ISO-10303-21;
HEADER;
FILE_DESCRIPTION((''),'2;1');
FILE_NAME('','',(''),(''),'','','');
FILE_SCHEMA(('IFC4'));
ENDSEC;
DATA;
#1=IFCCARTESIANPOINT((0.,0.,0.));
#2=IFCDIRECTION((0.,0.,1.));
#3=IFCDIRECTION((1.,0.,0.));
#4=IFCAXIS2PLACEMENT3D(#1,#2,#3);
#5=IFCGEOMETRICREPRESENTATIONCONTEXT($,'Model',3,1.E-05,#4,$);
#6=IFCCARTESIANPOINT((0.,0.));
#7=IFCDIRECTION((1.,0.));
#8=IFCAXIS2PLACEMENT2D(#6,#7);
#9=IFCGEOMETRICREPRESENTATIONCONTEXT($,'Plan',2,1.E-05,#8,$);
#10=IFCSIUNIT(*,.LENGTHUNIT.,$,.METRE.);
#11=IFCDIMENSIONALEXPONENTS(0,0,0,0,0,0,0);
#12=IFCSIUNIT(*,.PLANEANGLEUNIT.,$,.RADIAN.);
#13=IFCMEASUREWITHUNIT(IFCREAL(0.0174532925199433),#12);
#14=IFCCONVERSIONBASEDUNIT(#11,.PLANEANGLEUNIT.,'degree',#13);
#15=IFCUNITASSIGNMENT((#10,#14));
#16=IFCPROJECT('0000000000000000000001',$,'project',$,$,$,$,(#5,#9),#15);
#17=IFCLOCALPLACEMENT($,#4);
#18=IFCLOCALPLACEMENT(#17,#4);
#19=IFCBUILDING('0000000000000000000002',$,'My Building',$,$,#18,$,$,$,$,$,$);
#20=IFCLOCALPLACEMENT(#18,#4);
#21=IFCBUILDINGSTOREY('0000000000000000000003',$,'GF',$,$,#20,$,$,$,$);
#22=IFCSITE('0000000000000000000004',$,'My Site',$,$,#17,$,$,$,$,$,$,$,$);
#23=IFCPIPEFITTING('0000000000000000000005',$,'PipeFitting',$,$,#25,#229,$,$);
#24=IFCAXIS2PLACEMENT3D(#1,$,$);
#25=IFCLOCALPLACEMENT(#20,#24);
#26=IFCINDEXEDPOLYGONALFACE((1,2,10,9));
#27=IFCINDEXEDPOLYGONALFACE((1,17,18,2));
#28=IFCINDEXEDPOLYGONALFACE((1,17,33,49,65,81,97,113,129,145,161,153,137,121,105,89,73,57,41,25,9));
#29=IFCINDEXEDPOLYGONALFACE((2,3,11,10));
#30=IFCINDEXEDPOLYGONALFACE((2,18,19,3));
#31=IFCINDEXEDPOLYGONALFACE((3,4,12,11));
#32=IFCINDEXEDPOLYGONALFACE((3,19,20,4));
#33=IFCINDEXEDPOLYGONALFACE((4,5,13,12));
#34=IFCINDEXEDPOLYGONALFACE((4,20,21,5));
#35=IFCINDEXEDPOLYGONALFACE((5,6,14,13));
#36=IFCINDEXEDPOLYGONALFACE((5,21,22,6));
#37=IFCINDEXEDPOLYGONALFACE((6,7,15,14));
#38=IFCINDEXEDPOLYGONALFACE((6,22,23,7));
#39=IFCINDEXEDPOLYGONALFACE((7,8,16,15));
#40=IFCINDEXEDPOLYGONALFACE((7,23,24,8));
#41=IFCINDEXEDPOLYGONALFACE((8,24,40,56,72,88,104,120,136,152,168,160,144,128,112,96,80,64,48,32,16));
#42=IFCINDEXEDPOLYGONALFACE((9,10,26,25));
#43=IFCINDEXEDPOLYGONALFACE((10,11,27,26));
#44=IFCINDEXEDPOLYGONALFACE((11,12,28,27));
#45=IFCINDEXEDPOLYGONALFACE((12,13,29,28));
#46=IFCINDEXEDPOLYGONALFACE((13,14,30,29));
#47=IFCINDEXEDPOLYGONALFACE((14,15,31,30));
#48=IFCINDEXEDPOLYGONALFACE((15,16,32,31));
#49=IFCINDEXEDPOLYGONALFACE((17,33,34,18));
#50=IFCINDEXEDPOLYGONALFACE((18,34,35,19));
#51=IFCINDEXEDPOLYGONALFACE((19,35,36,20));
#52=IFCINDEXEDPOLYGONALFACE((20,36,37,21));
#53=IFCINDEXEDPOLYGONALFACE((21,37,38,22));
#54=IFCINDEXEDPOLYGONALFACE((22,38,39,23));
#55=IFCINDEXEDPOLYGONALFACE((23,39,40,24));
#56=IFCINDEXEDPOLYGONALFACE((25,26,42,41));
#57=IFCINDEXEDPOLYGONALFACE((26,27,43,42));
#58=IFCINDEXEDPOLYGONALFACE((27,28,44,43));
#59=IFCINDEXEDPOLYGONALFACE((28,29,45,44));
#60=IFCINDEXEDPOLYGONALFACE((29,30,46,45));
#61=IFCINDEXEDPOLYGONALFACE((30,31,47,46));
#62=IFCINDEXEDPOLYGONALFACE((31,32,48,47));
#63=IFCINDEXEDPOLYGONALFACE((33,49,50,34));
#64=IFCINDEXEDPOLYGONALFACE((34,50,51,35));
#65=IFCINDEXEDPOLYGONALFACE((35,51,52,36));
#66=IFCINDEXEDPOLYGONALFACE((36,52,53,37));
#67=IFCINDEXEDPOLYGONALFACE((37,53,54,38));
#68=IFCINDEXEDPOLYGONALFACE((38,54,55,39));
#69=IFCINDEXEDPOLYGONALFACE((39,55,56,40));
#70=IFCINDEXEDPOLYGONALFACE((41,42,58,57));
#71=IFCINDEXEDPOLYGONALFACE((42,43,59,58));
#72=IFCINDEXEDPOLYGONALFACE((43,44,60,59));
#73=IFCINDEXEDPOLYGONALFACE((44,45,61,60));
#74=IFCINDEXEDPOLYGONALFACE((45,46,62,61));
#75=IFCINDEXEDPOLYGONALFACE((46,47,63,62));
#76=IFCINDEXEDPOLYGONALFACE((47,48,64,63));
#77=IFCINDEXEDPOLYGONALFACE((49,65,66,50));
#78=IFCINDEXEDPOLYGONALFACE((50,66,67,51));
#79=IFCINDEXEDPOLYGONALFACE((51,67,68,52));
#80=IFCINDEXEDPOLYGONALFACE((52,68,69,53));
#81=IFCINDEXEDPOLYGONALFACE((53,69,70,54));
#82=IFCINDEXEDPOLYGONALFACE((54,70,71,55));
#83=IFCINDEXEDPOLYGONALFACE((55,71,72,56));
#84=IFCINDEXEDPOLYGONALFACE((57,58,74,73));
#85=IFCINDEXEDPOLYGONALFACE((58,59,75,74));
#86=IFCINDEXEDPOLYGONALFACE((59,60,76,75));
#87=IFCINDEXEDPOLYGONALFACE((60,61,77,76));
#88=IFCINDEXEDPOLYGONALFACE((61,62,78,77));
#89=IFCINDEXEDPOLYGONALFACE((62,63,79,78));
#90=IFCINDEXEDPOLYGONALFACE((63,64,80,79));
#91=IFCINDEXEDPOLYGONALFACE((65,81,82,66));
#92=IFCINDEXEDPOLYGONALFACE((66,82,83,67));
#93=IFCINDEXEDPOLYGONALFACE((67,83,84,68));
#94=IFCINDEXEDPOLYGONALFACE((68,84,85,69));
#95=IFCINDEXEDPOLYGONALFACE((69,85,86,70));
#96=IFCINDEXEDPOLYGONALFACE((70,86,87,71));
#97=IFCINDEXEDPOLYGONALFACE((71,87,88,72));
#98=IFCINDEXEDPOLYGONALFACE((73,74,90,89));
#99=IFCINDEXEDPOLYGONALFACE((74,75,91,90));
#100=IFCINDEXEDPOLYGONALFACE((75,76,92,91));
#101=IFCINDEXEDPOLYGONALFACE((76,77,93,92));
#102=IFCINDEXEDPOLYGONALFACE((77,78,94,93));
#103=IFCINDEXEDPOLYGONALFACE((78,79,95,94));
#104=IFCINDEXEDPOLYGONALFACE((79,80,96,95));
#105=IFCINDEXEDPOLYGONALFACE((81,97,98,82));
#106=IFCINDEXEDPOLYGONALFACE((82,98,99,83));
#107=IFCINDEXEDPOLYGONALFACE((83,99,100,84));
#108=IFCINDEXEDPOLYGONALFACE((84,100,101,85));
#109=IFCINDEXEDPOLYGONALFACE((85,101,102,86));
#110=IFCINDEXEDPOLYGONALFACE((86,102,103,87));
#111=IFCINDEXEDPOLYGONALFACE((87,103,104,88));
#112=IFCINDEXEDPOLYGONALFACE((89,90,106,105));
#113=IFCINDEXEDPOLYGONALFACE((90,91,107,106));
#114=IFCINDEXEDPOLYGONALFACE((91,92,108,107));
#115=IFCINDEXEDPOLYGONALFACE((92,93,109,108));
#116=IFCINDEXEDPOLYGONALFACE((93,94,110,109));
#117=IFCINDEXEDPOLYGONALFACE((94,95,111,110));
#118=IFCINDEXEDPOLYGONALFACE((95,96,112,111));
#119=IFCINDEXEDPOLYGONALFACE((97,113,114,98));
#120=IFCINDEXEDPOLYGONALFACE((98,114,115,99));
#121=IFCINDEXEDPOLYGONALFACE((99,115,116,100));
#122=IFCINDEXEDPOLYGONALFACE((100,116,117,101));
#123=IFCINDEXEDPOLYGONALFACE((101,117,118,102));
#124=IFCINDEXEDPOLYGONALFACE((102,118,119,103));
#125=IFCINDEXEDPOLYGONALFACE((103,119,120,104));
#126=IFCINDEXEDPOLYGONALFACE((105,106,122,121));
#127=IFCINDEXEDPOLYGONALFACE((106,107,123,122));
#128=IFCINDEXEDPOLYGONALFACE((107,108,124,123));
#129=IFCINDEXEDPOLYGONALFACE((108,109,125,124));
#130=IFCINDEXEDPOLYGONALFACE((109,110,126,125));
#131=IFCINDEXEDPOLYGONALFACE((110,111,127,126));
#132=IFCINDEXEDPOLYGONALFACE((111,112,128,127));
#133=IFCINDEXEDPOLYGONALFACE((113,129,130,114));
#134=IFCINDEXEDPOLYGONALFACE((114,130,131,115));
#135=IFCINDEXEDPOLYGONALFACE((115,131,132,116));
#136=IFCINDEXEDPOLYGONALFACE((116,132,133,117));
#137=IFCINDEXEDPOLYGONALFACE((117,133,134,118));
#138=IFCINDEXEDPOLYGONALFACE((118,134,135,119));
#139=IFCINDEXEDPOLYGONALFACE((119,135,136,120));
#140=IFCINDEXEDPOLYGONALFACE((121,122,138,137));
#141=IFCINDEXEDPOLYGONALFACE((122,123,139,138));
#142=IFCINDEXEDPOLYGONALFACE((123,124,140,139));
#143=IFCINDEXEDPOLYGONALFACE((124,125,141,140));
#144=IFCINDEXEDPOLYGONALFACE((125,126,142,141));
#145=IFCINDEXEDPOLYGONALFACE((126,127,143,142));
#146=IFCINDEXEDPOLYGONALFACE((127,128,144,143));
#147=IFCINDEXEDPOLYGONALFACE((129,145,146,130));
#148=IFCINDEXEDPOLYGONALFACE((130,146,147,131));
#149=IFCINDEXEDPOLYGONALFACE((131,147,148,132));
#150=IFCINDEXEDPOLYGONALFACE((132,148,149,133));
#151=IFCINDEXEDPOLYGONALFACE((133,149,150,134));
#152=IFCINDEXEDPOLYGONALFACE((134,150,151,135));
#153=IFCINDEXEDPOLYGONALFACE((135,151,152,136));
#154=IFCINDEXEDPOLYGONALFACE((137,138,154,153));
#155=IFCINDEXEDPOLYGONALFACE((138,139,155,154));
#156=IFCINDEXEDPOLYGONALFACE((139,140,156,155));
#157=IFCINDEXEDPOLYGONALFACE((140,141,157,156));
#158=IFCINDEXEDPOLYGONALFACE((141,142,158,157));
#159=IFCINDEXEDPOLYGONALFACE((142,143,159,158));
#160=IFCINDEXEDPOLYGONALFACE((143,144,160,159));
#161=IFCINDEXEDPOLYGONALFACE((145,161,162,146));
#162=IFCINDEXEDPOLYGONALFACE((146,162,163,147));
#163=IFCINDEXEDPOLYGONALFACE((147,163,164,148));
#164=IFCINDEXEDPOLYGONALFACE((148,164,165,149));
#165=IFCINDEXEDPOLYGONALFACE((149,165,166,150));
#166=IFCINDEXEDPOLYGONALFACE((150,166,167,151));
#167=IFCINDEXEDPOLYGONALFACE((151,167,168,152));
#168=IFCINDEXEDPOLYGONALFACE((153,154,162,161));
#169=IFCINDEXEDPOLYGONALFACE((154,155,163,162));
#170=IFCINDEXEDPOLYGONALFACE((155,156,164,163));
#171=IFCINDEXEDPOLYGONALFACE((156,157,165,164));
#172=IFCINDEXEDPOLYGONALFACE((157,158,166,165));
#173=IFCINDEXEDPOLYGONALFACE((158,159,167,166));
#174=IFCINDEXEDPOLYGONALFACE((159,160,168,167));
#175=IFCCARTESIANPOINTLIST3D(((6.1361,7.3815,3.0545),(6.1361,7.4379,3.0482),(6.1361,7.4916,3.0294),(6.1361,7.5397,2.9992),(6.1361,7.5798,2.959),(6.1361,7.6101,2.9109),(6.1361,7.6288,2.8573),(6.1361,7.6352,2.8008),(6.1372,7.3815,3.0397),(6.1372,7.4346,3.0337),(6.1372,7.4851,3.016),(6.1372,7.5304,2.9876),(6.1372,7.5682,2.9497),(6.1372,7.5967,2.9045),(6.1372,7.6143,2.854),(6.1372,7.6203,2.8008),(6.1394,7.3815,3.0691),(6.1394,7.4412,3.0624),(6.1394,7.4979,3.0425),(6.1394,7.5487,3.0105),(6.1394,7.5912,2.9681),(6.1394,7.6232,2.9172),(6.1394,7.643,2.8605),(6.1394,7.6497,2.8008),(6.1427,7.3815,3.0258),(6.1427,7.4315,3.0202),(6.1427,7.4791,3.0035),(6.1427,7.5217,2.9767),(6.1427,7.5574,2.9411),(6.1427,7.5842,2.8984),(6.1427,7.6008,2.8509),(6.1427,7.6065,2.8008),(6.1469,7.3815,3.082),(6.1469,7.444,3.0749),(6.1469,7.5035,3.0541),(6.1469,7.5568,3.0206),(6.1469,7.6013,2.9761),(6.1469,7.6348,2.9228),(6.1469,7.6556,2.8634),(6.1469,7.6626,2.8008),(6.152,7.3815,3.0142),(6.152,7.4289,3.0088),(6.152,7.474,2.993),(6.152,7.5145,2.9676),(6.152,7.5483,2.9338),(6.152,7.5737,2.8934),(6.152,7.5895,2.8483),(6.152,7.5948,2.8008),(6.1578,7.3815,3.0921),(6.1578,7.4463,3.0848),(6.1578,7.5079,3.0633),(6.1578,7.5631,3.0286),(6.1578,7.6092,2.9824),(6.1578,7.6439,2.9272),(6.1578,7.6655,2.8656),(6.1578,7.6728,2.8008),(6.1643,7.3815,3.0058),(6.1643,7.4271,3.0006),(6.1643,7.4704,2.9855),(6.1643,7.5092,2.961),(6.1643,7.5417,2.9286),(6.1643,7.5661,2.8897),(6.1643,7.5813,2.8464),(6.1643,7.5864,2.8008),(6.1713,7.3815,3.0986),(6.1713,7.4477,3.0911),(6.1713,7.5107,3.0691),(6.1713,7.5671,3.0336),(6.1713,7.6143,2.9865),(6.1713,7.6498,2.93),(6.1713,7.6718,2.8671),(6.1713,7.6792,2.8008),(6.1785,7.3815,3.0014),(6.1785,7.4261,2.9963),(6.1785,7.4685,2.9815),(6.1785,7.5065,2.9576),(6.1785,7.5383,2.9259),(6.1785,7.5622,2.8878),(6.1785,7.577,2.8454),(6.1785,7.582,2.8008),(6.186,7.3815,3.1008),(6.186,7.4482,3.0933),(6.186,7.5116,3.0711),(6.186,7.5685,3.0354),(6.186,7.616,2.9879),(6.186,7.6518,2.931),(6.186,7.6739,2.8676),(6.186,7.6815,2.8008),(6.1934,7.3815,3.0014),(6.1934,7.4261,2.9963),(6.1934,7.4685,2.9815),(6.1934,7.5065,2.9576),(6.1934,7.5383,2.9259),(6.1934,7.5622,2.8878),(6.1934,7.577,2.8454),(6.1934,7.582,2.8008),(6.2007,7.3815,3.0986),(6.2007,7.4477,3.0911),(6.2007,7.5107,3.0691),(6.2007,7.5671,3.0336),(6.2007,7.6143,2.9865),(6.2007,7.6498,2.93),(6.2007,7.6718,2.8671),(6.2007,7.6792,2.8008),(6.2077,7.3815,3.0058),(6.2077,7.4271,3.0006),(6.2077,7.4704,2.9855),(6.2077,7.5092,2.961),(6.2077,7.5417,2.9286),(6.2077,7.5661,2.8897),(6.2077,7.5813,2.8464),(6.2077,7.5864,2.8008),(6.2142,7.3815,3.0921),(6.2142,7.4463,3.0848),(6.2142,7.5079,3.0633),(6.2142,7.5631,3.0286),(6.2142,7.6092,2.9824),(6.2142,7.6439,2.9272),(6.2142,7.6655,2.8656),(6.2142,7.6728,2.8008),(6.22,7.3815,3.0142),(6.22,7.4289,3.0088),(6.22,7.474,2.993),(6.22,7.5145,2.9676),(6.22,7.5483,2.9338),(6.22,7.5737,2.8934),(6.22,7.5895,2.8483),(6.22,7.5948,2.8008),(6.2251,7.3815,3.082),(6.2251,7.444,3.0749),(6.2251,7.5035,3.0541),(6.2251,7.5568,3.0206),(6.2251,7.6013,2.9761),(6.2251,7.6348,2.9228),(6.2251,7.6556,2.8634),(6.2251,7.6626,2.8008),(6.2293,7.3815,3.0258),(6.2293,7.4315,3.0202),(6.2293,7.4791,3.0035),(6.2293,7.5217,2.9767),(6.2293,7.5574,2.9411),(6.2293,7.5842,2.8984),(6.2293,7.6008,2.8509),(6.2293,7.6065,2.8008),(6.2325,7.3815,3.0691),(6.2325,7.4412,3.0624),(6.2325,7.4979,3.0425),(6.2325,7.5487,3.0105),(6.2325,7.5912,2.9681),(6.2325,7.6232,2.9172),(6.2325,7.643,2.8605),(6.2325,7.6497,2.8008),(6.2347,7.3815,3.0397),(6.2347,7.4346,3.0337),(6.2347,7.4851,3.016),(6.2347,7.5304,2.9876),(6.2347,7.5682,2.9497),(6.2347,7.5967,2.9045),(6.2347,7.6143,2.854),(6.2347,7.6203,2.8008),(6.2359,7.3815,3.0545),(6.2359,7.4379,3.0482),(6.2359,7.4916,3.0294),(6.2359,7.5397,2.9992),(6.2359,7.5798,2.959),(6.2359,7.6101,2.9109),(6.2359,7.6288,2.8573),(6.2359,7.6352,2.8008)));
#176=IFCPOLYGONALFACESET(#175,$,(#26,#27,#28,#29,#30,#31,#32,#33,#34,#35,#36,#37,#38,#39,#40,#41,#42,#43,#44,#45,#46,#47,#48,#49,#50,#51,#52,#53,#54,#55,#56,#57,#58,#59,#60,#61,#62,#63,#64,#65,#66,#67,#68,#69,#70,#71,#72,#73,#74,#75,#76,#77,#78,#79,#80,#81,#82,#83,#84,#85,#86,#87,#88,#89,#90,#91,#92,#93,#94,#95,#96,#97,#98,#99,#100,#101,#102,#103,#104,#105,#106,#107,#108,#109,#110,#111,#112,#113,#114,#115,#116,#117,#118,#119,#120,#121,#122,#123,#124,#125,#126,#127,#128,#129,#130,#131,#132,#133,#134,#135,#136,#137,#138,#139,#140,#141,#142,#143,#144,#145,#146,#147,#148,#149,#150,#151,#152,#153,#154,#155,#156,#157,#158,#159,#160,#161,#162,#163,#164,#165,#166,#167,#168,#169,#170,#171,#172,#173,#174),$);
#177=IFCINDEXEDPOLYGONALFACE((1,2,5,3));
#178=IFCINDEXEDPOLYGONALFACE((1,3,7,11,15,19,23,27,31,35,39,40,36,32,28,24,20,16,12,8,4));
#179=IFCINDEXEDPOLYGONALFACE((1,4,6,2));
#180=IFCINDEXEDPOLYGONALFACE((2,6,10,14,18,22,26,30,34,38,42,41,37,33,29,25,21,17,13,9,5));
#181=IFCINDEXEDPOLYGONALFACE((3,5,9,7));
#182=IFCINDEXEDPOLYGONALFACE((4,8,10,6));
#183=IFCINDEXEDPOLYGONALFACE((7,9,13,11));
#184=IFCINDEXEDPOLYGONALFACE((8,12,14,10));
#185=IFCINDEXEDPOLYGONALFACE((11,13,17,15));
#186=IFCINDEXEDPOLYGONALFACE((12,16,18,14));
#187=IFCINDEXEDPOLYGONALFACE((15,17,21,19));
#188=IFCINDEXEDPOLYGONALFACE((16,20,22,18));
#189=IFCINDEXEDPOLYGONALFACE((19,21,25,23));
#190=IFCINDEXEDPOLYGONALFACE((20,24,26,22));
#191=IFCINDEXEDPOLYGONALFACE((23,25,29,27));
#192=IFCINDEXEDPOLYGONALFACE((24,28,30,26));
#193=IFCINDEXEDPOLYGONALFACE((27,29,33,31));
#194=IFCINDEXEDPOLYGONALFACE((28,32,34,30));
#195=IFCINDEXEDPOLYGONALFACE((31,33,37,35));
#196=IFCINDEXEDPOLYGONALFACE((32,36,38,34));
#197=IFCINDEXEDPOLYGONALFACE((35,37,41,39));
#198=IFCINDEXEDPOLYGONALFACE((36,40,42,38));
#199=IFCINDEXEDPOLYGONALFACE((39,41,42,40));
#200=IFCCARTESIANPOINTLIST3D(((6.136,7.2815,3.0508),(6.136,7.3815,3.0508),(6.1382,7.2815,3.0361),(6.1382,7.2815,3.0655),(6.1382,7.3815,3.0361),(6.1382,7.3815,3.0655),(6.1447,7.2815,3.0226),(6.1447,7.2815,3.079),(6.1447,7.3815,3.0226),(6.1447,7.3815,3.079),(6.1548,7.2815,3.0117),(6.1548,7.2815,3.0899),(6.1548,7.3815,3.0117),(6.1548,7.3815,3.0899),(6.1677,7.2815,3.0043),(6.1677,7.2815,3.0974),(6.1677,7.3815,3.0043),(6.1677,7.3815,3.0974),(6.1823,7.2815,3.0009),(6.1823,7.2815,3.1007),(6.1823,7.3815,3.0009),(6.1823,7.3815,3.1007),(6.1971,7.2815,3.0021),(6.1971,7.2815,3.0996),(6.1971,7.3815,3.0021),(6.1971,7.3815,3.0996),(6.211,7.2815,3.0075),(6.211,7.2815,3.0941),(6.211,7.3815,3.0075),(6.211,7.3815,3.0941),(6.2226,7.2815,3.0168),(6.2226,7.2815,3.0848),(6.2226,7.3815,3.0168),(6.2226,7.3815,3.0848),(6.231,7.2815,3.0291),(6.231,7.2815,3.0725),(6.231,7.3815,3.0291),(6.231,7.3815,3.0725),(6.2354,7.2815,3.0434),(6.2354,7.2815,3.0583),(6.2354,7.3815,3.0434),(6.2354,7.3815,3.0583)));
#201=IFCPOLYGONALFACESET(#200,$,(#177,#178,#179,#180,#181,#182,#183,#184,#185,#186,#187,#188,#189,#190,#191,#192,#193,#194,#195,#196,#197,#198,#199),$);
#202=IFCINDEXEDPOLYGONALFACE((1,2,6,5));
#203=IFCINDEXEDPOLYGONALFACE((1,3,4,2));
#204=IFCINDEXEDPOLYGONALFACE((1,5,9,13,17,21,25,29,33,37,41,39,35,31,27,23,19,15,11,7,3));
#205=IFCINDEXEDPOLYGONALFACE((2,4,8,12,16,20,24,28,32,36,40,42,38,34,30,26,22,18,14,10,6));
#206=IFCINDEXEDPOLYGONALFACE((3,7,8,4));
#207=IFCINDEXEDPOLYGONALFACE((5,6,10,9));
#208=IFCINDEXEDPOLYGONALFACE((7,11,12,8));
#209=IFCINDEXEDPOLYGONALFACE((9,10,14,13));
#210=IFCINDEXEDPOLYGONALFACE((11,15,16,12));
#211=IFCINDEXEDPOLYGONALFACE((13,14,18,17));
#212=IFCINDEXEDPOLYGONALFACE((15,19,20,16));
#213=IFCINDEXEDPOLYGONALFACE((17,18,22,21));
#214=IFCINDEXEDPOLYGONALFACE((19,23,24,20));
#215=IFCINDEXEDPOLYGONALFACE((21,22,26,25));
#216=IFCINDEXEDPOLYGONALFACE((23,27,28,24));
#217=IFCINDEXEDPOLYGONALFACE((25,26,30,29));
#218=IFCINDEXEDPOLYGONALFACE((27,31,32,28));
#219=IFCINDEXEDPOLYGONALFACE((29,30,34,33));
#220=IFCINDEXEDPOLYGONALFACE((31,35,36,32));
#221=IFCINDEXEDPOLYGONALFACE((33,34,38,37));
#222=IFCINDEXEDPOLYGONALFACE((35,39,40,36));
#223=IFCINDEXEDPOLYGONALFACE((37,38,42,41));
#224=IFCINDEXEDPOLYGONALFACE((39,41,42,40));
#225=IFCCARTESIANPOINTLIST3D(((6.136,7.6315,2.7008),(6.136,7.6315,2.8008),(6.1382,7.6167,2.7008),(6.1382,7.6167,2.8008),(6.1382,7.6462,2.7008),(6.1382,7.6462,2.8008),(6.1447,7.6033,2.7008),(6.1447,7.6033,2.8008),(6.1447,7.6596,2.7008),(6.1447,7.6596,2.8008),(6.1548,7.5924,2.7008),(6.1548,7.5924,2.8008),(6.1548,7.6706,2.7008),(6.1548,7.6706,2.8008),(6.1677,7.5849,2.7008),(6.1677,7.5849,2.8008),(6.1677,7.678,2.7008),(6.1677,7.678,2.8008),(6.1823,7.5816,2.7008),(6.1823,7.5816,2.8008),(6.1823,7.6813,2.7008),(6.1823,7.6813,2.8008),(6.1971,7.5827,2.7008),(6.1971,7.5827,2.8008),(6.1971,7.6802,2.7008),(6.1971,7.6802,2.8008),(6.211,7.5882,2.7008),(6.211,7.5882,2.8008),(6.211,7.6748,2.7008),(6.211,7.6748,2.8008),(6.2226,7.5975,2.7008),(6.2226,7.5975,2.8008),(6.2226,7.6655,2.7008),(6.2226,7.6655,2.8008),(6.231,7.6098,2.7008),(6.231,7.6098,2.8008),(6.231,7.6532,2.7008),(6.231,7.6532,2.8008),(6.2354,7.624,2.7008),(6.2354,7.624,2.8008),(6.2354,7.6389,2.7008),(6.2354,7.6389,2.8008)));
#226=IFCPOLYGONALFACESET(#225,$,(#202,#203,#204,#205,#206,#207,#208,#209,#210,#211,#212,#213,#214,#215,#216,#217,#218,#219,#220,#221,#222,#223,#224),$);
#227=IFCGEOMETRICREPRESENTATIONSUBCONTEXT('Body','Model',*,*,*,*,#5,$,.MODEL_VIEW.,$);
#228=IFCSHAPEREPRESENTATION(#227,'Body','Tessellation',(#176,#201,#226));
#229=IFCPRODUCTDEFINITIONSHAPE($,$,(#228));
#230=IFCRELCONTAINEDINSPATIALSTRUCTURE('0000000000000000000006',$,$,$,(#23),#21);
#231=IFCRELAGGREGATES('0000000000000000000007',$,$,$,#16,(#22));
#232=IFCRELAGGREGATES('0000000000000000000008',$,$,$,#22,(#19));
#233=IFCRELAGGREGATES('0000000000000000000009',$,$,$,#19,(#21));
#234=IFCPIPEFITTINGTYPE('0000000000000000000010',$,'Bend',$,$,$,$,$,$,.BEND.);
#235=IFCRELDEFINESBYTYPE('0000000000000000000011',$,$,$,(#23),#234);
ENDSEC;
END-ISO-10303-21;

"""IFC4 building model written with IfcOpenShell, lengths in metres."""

from ifc_helpers import new_model, entity, si_unit, converted_unit, frame, origin_with_axes, origin_2d_with_axis, place, context, subcontext, project, spatial, circle, extrude, source, transform, mapped, type_object, type_shapes, element, save


model = new_model("IFC4")

# Units and contexts
model_context = context("Model", 3, precision=1e-05, world=origin_with_axes())
plan_context = context("Plan", 2, precision=1e-05, world=origin_2d_with_axis())
body_context_1 = subcontext(model_context, "Body", "Model", "MODEL_VIEW")
ifc_project = project(units=[si_unit("LENGTHUNIT", "METRE"), converted_unit("PLANEANGLEUNIT", "degree", entity("IfcReal", 0.0174532925199433), si_unit("PLANEANGLEUNIT", "RADIAN"), dimensions=[0, 0, 0, 0, 0, 0, 0])], contexts=[model_context, plan_context])

# Site, building, storey
site_placement = place(None, origin_with_axes())
site = spatial("IfcSite", under=ifc_project, at=site_placement, Name="My Site")
building_placement = place(site_placement, origin_with_axes())
building = spatial("IfcBuilding", under=site, at=building_placement, Name="My Building")
storey_placement = place(building_placement, origin_with_axes())
storey = spatial("IfcBuildingStorey", under=building, at=storey_placement, Name="GF")

# Pipe fitting
pipe_fitting_type = type_object("IfcPipeFittingType", Name="Bend", PredefinedType="BEND")
shared_shape_1 = source(origin_with_axes(), body_context_1, "Body", "SolidModel", [
    entity("IfcSweptDiskSolid", entity("IfcIndexedPolyCurve", entity("IfcCartesianPointList3D", [[0.0, 0.0, 0.1], [0.0, -0.0732, 0.2768], [0.0, -0.25, 0.35]]), [entity("IfcArcIndex", [1, 2, 3])]), 0.05),
    extrude(circle(Radius=0.05), origin_with_axes(), (0.0, 0.0, 1.0), 0.1),
    extrude(circle(Radius=0.05), frame((0.0, -0.25, 0.35), z_axis=(0.0, -1.0, 0.0), x_axis=(1.0, 0.0, 0.0)), (0.0, 0.0, 1.0), 0.1),
])
type_shapes(pipe_fitting_type, [shared_shape_1])
for number, where, z_axis, x_axis, name in (
    (1, (6.186, 7.2815, 3.0508), (0.0, 1.0, 0.0), (-1.0, 0.0, 0.0), "PipeFitting"),
):
    element("IfcPipeFitting", number, at=place(storey_placement, frame(where, z_axis=z_axis, x_axis=x_axis)), inside=storey, type_object=pipe_fitting_type, Name=name, context=body_context_1, shape_type="MappedRepresentation", body=[
        mapped(shared_shape_1, transform((0.0, 0.0, 0.0), x_axis=(1.0, 0.0, 0.0), y_axis=(0.0, 1.0, 0.0), z_axis=(0.0, 0.0, 1.0), scale=1.0)),
    ])

save(model, "model.ifc")
